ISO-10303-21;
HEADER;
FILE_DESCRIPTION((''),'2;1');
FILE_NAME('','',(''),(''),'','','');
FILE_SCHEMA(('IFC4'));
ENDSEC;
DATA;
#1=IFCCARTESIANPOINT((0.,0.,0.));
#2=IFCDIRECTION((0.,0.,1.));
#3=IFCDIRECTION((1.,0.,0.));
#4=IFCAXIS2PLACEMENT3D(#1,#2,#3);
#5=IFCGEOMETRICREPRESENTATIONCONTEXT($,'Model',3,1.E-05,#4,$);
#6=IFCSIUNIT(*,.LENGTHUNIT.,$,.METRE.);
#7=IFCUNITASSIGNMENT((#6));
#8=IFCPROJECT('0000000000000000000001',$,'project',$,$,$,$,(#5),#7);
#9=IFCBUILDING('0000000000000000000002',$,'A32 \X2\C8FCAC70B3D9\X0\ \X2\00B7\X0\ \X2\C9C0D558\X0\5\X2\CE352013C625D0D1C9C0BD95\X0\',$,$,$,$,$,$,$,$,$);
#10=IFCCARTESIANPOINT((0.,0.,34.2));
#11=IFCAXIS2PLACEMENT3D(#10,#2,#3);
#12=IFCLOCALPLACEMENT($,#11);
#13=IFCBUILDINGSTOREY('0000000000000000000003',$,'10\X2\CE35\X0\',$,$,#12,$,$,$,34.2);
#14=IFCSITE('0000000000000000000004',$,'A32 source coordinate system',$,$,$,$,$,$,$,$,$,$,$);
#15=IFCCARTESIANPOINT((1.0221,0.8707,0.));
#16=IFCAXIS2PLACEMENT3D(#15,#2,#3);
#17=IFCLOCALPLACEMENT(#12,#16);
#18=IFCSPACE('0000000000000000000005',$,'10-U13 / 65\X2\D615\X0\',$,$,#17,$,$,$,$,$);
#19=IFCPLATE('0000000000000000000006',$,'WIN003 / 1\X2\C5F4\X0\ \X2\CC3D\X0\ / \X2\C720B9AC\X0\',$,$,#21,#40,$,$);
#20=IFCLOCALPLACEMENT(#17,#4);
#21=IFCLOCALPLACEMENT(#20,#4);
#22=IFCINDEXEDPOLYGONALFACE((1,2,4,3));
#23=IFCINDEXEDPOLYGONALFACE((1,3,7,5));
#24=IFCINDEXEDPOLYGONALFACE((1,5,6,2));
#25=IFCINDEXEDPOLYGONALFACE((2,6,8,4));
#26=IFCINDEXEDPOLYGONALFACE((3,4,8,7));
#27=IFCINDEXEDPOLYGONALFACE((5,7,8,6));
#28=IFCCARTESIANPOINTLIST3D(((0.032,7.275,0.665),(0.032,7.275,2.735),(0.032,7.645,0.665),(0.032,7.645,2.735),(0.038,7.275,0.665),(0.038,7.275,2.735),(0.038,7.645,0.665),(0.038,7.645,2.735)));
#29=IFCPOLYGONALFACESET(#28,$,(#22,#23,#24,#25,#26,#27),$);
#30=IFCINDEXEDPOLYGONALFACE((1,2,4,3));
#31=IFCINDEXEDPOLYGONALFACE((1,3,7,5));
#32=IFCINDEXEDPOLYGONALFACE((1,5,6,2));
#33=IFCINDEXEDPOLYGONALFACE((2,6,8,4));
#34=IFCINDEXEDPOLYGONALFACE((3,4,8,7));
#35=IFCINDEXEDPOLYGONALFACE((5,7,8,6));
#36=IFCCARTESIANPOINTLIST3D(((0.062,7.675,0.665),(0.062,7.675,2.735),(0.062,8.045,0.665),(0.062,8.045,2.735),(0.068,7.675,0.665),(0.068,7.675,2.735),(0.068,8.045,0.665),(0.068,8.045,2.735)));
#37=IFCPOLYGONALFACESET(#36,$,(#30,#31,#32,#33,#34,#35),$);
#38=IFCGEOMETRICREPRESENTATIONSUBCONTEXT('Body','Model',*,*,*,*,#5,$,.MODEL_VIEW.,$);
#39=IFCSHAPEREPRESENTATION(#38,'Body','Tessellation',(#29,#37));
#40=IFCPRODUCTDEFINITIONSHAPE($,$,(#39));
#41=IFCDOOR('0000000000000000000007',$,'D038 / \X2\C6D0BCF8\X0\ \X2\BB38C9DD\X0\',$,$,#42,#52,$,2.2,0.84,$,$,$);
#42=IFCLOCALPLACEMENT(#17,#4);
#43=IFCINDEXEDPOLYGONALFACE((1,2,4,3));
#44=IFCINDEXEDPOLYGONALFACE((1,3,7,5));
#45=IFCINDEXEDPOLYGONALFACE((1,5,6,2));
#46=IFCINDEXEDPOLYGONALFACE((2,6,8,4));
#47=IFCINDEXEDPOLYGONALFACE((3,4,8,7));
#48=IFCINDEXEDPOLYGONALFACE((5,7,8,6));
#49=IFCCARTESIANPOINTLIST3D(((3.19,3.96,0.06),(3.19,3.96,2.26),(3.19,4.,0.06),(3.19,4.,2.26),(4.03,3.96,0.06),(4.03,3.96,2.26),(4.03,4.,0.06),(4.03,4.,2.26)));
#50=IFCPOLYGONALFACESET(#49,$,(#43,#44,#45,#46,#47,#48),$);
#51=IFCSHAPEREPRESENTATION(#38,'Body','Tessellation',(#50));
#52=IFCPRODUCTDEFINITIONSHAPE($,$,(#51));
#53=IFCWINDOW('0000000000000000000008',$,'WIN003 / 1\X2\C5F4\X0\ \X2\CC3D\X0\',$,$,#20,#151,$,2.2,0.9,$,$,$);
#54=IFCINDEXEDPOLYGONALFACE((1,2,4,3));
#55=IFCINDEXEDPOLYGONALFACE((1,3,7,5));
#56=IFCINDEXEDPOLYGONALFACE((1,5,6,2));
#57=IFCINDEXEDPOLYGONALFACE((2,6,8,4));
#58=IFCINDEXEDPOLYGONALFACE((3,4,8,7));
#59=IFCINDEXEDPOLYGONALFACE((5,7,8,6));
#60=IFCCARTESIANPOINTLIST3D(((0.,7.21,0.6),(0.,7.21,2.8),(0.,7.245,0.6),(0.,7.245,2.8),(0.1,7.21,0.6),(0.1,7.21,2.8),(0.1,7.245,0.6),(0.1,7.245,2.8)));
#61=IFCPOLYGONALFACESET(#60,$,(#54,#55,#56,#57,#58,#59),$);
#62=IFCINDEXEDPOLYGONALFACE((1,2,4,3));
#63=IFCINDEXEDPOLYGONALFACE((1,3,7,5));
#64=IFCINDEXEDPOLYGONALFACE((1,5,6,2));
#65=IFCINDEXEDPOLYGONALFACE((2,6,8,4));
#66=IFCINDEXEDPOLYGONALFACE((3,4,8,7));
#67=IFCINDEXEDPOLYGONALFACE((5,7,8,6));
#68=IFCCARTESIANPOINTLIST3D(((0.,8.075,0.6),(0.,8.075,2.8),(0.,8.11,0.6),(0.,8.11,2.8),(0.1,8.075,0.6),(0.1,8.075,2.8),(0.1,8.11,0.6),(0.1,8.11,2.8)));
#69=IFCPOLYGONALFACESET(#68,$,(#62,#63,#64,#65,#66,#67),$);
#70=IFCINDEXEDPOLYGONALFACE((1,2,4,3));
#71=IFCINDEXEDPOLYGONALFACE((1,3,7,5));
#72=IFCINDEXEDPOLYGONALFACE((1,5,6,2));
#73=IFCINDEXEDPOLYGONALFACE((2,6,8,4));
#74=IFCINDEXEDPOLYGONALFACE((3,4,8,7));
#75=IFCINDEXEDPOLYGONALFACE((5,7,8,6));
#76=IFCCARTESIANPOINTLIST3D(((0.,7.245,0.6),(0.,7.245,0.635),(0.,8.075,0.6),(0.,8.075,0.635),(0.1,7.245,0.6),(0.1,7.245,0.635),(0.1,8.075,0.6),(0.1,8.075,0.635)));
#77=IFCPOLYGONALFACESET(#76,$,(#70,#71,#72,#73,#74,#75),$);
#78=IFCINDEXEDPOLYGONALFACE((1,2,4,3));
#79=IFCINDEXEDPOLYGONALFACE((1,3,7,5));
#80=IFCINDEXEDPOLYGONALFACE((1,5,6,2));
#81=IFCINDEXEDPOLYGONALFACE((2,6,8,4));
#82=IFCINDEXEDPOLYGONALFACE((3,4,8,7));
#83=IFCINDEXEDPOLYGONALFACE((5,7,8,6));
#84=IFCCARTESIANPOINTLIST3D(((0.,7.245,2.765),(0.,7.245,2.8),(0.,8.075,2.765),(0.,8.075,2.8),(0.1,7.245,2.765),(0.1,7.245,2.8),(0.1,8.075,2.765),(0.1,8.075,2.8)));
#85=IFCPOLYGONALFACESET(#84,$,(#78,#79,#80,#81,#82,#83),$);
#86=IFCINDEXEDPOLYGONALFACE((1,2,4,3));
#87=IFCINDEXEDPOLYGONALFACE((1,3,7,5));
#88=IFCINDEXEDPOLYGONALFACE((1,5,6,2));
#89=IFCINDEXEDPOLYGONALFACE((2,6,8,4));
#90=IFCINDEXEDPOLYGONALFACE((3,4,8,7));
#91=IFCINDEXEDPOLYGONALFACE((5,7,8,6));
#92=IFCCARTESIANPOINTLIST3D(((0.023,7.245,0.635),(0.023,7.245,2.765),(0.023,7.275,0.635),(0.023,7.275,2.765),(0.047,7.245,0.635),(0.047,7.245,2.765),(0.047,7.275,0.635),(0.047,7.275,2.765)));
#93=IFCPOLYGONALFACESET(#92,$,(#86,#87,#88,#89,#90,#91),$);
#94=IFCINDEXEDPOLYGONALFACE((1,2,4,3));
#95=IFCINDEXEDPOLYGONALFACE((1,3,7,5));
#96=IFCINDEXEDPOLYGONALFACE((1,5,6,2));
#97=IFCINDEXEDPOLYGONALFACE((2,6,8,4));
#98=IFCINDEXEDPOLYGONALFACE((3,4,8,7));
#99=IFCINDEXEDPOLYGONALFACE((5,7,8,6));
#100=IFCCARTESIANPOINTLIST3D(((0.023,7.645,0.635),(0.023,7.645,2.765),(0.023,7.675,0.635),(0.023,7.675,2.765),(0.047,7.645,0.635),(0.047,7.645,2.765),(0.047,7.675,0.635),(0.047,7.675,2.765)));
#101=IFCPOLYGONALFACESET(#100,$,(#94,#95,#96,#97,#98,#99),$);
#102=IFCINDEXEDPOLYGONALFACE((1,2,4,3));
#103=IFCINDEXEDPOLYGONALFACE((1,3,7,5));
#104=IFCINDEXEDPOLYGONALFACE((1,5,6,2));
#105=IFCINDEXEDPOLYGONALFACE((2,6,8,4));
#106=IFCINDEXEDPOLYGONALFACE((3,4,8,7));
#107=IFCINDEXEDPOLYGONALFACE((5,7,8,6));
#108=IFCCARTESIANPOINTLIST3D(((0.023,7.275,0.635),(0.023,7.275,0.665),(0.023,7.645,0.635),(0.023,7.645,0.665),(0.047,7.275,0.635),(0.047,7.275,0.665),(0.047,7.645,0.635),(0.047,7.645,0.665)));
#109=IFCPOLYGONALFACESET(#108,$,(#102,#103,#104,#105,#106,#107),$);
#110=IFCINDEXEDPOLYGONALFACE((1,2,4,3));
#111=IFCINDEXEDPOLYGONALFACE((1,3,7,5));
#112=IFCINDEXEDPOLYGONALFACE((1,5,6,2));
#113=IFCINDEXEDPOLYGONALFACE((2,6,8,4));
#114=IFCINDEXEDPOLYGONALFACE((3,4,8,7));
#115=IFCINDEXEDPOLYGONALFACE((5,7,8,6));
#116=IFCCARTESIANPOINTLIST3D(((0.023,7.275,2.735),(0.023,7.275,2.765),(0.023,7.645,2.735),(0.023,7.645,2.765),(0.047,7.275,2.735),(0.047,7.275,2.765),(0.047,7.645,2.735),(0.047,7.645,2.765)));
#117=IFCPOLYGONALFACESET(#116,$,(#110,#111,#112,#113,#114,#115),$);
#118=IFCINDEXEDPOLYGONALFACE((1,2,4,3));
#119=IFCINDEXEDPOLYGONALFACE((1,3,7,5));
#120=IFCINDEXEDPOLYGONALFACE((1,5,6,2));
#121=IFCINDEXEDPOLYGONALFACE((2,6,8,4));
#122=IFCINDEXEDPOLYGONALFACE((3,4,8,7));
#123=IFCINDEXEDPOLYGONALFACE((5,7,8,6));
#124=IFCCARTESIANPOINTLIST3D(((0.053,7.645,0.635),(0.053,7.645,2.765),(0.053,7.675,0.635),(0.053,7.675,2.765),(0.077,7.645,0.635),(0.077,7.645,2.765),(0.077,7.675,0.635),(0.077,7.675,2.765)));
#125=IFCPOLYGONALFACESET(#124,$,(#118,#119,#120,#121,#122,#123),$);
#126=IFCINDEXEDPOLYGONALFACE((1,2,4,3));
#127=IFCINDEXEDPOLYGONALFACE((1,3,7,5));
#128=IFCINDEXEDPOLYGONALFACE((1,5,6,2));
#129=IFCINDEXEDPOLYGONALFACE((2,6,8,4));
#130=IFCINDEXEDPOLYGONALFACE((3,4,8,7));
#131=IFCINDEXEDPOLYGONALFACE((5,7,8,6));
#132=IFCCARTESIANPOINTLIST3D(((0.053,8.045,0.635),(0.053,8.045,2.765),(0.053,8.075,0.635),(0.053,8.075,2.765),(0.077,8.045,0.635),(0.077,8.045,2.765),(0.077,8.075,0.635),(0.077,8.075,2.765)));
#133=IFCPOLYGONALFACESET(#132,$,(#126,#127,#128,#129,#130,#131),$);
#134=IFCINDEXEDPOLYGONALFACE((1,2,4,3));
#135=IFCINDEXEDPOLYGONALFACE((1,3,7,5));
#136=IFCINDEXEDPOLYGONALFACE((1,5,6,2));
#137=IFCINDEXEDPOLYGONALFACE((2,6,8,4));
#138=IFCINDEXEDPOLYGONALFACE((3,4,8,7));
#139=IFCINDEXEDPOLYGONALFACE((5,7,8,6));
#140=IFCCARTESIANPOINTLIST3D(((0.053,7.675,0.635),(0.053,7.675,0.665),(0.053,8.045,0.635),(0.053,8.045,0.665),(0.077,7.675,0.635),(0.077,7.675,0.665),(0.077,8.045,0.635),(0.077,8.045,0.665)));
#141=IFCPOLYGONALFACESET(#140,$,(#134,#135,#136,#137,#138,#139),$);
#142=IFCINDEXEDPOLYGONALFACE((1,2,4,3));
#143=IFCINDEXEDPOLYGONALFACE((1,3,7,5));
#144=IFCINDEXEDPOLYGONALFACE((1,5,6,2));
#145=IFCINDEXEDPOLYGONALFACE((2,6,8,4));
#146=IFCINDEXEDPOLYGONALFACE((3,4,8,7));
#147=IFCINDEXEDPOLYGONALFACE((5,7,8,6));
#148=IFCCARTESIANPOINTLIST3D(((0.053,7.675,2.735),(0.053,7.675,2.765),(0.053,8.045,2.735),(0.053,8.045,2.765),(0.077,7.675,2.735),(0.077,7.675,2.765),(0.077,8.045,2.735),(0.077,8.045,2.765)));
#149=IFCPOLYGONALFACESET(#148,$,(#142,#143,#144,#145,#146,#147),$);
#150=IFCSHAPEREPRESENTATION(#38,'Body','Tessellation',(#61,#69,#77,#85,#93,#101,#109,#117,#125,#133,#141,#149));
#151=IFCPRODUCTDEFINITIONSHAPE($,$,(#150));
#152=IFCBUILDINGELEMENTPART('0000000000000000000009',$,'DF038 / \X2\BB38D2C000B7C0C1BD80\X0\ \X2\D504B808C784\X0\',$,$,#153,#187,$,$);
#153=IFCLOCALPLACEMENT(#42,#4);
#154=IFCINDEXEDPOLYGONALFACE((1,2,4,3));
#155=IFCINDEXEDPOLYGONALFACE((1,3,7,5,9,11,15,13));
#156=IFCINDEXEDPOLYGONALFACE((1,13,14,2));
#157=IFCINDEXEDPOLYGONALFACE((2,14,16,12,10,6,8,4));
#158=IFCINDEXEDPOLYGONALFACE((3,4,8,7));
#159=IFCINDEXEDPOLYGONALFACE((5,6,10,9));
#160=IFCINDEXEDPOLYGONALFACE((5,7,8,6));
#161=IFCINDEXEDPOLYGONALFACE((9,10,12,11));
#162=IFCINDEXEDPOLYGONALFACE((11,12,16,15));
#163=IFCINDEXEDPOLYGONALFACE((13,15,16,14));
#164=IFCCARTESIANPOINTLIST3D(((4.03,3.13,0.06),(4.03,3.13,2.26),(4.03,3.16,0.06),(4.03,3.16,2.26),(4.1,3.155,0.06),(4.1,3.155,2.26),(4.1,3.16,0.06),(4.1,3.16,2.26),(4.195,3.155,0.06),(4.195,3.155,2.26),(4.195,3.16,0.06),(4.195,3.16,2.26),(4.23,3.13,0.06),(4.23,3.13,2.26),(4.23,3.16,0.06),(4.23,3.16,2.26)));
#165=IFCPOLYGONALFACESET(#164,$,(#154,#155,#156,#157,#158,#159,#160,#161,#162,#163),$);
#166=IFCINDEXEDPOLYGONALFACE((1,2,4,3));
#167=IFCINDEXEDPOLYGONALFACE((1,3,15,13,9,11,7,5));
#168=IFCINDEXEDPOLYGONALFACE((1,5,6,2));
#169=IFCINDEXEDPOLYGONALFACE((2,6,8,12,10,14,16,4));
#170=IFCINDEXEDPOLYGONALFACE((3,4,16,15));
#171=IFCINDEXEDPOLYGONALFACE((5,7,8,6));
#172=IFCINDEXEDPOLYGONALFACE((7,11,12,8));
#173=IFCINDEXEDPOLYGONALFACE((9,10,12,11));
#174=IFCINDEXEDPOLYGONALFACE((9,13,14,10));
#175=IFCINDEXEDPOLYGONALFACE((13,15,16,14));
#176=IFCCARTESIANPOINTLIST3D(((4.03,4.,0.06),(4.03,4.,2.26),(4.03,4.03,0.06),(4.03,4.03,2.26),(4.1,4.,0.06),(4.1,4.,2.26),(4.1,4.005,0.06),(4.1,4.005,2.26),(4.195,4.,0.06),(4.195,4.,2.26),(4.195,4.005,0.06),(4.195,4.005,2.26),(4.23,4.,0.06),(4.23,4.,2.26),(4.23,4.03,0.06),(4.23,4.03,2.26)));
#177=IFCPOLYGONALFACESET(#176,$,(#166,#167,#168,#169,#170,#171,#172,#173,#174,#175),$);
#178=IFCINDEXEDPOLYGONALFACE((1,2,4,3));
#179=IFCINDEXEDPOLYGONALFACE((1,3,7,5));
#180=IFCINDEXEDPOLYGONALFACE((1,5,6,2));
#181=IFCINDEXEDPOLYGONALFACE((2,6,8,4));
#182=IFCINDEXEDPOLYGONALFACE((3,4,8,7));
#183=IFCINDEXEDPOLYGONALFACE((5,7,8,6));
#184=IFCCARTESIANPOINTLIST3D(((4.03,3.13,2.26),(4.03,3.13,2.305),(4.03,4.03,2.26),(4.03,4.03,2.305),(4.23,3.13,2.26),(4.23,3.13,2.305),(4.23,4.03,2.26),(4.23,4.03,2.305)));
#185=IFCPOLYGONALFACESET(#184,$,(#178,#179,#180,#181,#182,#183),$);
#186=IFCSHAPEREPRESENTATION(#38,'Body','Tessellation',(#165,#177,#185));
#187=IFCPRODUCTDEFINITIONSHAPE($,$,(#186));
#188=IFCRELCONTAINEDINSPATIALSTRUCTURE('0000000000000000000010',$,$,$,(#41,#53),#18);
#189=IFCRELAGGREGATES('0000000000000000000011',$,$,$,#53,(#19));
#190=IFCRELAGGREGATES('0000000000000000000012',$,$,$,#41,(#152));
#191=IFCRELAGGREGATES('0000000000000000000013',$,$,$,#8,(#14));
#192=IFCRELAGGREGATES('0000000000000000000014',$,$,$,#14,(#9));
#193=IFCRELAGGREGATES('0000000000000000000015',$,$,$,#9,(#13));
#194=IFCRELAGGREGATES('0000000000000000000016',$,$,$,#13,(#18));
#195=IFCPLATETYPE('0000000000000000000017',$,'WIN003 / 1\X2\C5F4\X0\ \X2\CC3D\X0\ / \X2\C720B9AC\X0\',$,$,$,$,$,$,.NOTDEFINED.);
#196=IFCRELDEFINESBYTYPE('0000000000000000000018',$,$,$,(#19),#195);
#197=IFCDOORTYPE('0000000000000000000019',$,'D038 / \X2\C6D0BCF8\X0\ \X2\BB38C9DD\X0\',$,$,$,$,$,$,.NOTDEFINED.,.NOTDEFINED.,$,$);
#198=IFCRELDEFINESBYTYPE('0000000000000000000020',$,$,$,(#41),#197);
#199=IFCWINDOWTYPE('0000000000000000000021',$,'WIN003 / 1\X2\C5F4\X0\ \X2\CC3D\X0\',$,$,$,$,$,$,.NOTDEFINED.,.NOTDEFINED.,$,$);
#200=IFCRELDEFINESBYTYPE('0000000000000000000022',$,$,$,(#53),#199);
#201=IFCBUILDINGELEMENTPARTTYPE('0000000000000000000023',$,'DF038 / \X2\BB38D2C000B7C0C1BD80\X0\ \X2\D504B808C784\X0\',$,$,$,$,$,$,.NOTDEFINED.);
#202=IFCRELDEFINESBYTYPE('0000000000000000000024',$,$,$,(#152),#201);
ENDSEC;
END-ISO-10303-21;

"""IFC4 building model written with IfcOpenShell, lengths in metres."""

from ifc_helpers import new_model, si_unit, frame, origin, origin_with_axes, place, context, subcontext, project, spatial, polyline, outline, extrude, source, transform, mapped, type_object, type_shapes, element, aggregate, save


model = new_model("IFC4")

# Units and contexts
model_context = context("Model", 3, precision=1e-05, world=origin_with_axes())
body_context = subcontext(model_context, "Body", "Model", "MODEL_VIEW")
ifc_project = project(units=[si_unit("LENGTHUNIT", "METRE")], contexts=[model_context])

# Plate
storey_placement = place(None, frame((0.0, 0.0, 34.2), z_axis=(0.0, 0.0, 1.0), x_axis=(1.0, 0.0, 0.0)))
space_placement = place(storey_placement, frame((1.0221, 0.8707, 0.0), z_axis=(0.0, 0.0, 1.0), x_axis=(1.0, 0.0, 0.0)))
plate_type_1 = type_object("IfcPlateType", Name="WIN003 / 1열 창 / 유리", PredefinedType="NOTDEFINED")
shared_shape_1 = source(origin(), body_context, "Body", "SweptSolid", [
    extrude(outline(polyline([(0.032, 7.275), (0.032, 7.645), (0.038, 7.645), (0.038, 7.275), (0.032, 7.275)])), frame((0.0, 0.0, 0.665)), (0.0, 0.0, 1.0), 2.07),
    extrude(outline(polyline([(0.062, 7.675), (0.062, 8.045), (0.068, 8.045), (0.068, 7.675), (0.062, 7.675)])), frame((0.0, 0.0, 0.665)), (0.0, 0.0, 1.0), 2.07),
])
type_shapes(plate_type_1, [shared_shape_1])
window_1_placement = place(space_placement, origin_with_axes())
plate_1_placement = place(window_1_placement, origin_with_axes())
plate_1 = element("IfcPlate", 1, at=plate_1_placement, type_object=plate_type_1, Name="WIN003 / 1열 창 / 유리", context=body_context, shape_type="MappedRepresentation", body=[
    mapped(shared_shape_1, transform((0.0, 0.0, 0.0), scale=1.0)),
])

# Site, building, storey, space
site = spatial("IfcSite", under=ifc_project, Name="A32 source coordinate system")
building = spatial("IfcBuilding", under=site, Name="A32 주거동 · 지하5층–옥탑지붕")
storey = spatial("IfcBuildingStorey", under=building, at=storey_placement, Name="10층", Elevation=34.2)
space = spatial("IfcSpace", under=storey, at=space_placement, Name="10-U13 / 65형")

# Door
door_type_1 = type_object("IfcDoorType", Name="D038 / 원본 문짝", OperationType="NOTDEFINED", PredefinedType="NOTDEFINED")
shared_shape_2 = source(origin(), body_context, "Body", "SweptSolid", [
    extrude(outline(polyline([(3.19, 3.96), (3.19, 4.0), (4.03, 4.0), (4.03, 3.96), (3.19, 3.96)])), frame((0.0, 0.0, 0.06)), (0.0, 0.0, 1.0), 2.2),
])
type_shapes(door_type_1, [shared_shape_2])
door_1_placement = place(space_placement, origin_with_axes())
door_1 = element("IfcDoor", 2, at=door_1_placement, inside=space, type_object=door_type_1, Name="D038 / 원본 문짝", OverallHeight=2.2, OverallWidth=0.84, context=body_context, shape_type="MappedRepresentation", body=[
    mapped(shared_shape_2, transform((0.0, 0.0, 0.0), scale=1.0)),
])

# Window
window_type_1 = type_object("IfcWindowType", Name="WIN003 / 1열 창", PartitioningType="NOTDEFINED", PredefinedType="NOTDEFINED")
shared_shape_3 = source(origin(), body_context, "Body", "SweptSolid", [
    extrude(outline(polyline([(0.0, 7.21), (0.0, 7.245), (0.1, 7.245), (0.1, 7.21), (0.0, 7.21)])), frame((0.0, 0.0, 0.6)), (0.0, 0.0, 1.0), 2.2),
    extrude(outline(polyline([(0.0, 8.075), (0.0, 8.11), (0.1, 8.11), (0.1, 8.075), (0.0, 8.075)])), frame((0.0, 0.0, 0.6)), (0.0, 0.0, 1.0), 2.2),
    extrude(outline(polyline([(0.0, 7.245), (0.0, 8.075), (0.1, 8.075), (0.1, 7.245), (0.0, 7.245)])), frame((0.0, 0.0, 0.6)), (0.0, 0.0, 1.0), 0.035),
    extrude(outline(polyline([(0.0, 7.245), (0.0, 8.075), (0.1, 8.075), (0.1, 7.245), (0.0, 7.245)])), frame((0.0, 0.0, 2.765)), (0.0, 0.0, 1.0), 0.035),
    extrude(outline(polyline([(0.023, 7.245), (0.023, 7.275), (0.047, 7.275), (0.047, 7.245), (0.023, 7.245)])), frame((0.0, 0.0, 0.635)), (0.0, 0.0, 1.0), 2.13),
    extrude(outline(polyline([(0.023, 7.645), (0.023, 7.675), (0.047, 7.675), (0.047, 7.645), (0.023, 7.645)])), frame((0.0, 0.0, 0.635)), (0.0, 0.0, 1.0), 2.13),
    extrude(outline(polyline([(0.023, 7.275), (0.023, 7.645), (0.047, 7.645), (0.047, 7.275), (0.023, 7.275)])), frame((0.0, 0.0, 0.635)), (0.0, 0.0, 1.0), 0.03),
    extrude(outline(polyline([(0.023, 7.275), (0.023, 7.645), (0.047, 7.645), (0.047, 7.275), (0.023, 7.275)])), frame((0.0, 0.0, 2.735)), (0.0, 0.0, 1.0), 0.03),
    extrude(outline(polyline([(0.053, 7.645), (0.053, 7.675), (0.077, 7.675), (0.077, 7.645), (0.053, 7.645)])), frame((0.0, 0.0, 0.635)), (0.0, 0.0, 1.0), 2.13),
    extrude(outline(polyline([(0.053, 8.045), (0.053, 8.075), (0.077, 8.075), (0.077, 8.045), (0.053, 8.045)])), frame((0.0, 0.0, 0.635)), (0.0, 0.0, 1.0), 2.13),
    extrude(outline(polyline([(0.053, 7.675), (0.053, 8.045), (0.077, 8.045), (0.077, 7.675), (0.053, 7.675)])), frame((0.0, 0.0, 0.635)), (0.0, 0.0, 1.0), 0.03),
    extrude(outline(polyline([(0.053, 7.675), (0.053, 8.045), (0.077, 8.045), (0.077, 7.675), (0.053, 7.675)])), frame((0.0, 0.0, 2.735)), (0.0, 0.0, 1.0), 0.03),
])
type_shapes(window_type_1, [shared_shape_3])
window_1 = element("IfcWindow", 3, at=window_1_placement, inside=space, type_object=window_type_1, Name="WIN003 / 1열 창", OverallHeight=2.2, OverallWidth=0.9, context=body_context, shape_type="MappedRepresentation", body=[
    mapped(shared_shape_3, transform((0.0, 0.0, 0.0), scale=1.0)),
])
aggregate(window_1, [plate_1])

# Building element part
building_element_part_type_1 = type_object("IfcBuildingElementPartType", Name="DF038 / 문틀·상부 프레임", PredefinedType="NOTDEFINED")
shared_shape_4 = source(origin(), body_context, "Body", "SweptSolid", [
    extrude(outline(polyline([(4.03, 3.16), (4.1, 3.16), (4.1, 3.155), (4.195, 3.155), (4.195, 3.16), (4.23, 3.16), (4.23, 3.13), (4.03, 3.13), (4.03, 3.16)])), frame((0.0, 0.0, 0.06)), (0.0, 0.0, 1.0), 2.2),
    extrude(outline(polyline([(4.23, 4.03), (4.23, 4.0), (4.195, 4.0), (4.195, 4.005), (4.1, 4.005), (4.1, 4.0), (4.03, 4.0), (4.03, 4.03), (4.23, 4.03)])), frame((0.0, 0.0, 0.06)), (0.0, 0.0, 1.0), 2.2),
    extrude(outline(polyline([(4.03, 3.13), (4.03, 4.03), (4.23, 4.03), (4.23, 3.13), (4.03, 3.13)])), frame((0.0, 0.0, 2.26)), (0.0, 0.0, 1.0), 0.045),
])
type_shapes(building_element_part_type_1, [shared_shape_4])
building_element_part_1_placement = place(door_1_placement, origin_with_axes())
building_element_part_1 = element("IfcBuildingElementPart", 4, at=building_element_part_1_placement, type_object=building_element_part_type_1, Name="DF038 / 문틀·상부 프레임", context=body_context, shape_type="MappedRepresentation", body=[
    mapped(shared_shape_4, transform((0.0, 0.0, 0.0), scale=1.0)),
])
aggregate(door_1, [building_element_part_1])

save(model, "model.ifc")
